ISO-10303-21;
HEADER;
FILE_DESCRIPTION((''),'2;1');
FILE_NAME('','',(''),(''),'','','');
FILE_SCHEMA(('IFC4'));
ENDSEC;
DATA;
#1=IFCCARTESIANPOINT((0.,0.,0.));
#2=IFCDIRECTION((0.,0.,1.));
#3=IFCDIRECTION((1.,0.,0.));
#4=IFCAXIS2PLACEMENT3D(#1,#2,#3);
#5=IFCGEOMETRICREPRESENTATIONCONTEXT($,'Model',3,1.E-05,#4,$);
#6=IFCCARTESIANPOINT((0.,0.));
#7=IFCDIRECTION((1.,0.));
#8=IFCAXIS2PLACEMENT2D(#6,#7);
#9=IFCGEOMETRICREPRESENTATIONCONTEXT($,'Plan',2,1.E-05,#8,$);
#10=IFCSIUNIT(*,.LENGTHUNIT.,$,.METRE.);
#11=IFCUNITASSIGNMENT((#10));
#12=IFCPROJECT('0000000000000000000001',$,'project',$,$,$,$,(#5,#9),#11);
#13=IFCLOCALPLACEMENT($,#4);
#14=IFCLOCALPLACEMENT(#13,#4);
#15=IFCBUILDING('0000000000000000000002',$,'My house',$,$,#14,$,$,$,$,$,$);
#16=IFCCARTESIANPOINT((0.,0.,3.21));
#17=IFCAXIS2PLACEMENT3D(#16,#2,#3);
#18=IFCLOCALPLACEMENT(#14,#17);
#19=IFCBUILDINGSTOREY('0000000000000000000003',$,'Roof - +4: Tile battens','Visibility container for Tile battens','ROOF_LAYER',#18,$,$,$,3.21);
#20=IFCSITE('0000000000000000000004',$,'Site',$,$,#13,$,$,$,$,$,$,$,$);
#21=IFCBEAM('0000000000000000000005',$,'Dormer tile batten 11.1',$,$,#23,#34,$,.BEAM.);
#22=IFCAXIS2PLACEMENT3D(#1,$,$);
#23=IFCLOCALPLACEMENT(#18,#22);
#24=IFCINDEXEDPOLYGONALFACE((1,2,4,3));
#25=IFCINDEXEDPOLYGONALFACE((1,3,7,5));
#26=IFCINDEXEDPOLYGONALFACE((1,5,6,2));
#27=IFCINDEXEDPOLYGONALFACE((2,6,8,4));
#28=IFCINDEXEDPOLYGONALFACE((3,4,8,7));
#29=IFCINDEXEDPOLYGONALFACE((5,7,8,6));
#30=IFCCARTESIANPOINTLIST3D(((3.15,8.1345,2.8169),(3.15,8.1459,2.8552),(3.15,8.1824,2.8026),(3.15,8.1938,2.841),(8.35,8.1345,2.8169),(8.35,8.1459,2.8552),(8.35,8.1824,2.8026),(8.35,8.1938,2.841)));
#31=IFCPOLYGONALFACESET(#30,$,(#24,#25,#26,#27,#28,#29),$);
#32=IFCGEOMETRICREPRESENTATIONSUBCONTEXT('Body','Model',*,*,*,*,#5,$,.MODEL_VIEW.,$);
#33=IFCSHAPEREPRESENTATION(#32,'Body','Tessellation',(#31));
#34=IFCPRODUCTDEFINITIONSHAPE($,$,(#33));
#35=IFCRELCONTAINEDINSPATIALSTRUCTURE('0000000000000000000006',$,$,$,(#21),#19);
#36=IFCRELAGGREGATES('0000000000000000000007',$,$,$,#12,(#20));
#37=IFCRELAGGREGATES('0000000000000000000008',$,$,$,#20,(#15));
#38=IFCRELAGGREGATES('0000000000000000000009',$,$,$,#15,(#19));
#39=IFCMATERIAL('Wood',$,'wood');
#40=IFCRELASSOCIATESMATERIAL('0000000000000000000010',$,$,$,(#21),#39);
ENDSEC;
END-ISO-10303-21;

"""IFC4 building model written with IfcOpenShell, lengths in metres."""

from ifc_helpers import new_model, si_unit, frame, origin_with_axes, origin_2d_with_axis, place, context, subcontext, project, spatial, rectangle, extrude, clip, halfspace, material, element, save


model = new_model("IFC4")

# Units and contexts
model_context = context("Model", 3, precision=1e-05, world=origin_with_axes())
plan_context = context("Plan", 2, precision=1e-05, world=origin_2d_with_axis())
body_context = subcontext(model_context, "Body", "Model", "MODEL_VIEW")
ifc_project = project(units=[si_unit("LENGTHUNIT", "METRE")], contexts=[model_context, plan_context])

# Site, building, storey
site_placement = place(None, origin_with_axes())
site = spatial("IfcSite", under=ifc_project, at=site_placement, Name="Site")
building_placement = place(site_placement, origin_with_axes())
building = spatial("IfcBuilding", under=site, at=building_placement, Name="My house")
storey_placement = place(building_placement, frame((0.0, 0.0, 3.21), z_axis=(0.0, 0.0, 1.0), x_axis=(1.0, 0.0, 0.0)))
storey = spatial("IfcBuildingStorey", under=building, at=storey_placement, Name="Roof - +4: Tile battens", Description="Visibility container for Tile battens", ObjectType="ROOF_LAYER", Elevation=3.21)

# Beam
ifc_material = material(Name="Wood", Category="wood")
beam_1_placement = place(storey_placement, frame((3.15, 8.1642, 2.8289), z_axis=(0.0, 0.28578, 0.958295), x_axis=(1.0, 0.0, 0.0)))
element("IfcBeam", 1, at=beam_1_placement, inside=storey, material=ifc_material, Name="Dormer tile batten 11.1", PredefinedType="BEAM", context=body_context, shape_type="Clipping", body=[
    clip(clip(extrude(rectangle(XDim=0.05, YDim=0.04), frame((0.0, 0.0, 0.0), z_axis=(1.0, 0.0, 0.0), x_axis=(0.0, 1.0, 0.0)), (0.0, 0.0, 1.0), 5.2), halfspace(frame((-3.15, -2.2647, -6.9771), z_axis=(0.0, -0.958295, -0.28578), x_axis=(-1.0, 0.0, 0.0)), False)), halfspace(frame((-3.15, 1.9518, -5.7197), z_axis=(0.0, 0.958295, 0.28578), x_axis=(1.0, 0.0, 0.0)), False)),
])

save(model, "model.ifc")
